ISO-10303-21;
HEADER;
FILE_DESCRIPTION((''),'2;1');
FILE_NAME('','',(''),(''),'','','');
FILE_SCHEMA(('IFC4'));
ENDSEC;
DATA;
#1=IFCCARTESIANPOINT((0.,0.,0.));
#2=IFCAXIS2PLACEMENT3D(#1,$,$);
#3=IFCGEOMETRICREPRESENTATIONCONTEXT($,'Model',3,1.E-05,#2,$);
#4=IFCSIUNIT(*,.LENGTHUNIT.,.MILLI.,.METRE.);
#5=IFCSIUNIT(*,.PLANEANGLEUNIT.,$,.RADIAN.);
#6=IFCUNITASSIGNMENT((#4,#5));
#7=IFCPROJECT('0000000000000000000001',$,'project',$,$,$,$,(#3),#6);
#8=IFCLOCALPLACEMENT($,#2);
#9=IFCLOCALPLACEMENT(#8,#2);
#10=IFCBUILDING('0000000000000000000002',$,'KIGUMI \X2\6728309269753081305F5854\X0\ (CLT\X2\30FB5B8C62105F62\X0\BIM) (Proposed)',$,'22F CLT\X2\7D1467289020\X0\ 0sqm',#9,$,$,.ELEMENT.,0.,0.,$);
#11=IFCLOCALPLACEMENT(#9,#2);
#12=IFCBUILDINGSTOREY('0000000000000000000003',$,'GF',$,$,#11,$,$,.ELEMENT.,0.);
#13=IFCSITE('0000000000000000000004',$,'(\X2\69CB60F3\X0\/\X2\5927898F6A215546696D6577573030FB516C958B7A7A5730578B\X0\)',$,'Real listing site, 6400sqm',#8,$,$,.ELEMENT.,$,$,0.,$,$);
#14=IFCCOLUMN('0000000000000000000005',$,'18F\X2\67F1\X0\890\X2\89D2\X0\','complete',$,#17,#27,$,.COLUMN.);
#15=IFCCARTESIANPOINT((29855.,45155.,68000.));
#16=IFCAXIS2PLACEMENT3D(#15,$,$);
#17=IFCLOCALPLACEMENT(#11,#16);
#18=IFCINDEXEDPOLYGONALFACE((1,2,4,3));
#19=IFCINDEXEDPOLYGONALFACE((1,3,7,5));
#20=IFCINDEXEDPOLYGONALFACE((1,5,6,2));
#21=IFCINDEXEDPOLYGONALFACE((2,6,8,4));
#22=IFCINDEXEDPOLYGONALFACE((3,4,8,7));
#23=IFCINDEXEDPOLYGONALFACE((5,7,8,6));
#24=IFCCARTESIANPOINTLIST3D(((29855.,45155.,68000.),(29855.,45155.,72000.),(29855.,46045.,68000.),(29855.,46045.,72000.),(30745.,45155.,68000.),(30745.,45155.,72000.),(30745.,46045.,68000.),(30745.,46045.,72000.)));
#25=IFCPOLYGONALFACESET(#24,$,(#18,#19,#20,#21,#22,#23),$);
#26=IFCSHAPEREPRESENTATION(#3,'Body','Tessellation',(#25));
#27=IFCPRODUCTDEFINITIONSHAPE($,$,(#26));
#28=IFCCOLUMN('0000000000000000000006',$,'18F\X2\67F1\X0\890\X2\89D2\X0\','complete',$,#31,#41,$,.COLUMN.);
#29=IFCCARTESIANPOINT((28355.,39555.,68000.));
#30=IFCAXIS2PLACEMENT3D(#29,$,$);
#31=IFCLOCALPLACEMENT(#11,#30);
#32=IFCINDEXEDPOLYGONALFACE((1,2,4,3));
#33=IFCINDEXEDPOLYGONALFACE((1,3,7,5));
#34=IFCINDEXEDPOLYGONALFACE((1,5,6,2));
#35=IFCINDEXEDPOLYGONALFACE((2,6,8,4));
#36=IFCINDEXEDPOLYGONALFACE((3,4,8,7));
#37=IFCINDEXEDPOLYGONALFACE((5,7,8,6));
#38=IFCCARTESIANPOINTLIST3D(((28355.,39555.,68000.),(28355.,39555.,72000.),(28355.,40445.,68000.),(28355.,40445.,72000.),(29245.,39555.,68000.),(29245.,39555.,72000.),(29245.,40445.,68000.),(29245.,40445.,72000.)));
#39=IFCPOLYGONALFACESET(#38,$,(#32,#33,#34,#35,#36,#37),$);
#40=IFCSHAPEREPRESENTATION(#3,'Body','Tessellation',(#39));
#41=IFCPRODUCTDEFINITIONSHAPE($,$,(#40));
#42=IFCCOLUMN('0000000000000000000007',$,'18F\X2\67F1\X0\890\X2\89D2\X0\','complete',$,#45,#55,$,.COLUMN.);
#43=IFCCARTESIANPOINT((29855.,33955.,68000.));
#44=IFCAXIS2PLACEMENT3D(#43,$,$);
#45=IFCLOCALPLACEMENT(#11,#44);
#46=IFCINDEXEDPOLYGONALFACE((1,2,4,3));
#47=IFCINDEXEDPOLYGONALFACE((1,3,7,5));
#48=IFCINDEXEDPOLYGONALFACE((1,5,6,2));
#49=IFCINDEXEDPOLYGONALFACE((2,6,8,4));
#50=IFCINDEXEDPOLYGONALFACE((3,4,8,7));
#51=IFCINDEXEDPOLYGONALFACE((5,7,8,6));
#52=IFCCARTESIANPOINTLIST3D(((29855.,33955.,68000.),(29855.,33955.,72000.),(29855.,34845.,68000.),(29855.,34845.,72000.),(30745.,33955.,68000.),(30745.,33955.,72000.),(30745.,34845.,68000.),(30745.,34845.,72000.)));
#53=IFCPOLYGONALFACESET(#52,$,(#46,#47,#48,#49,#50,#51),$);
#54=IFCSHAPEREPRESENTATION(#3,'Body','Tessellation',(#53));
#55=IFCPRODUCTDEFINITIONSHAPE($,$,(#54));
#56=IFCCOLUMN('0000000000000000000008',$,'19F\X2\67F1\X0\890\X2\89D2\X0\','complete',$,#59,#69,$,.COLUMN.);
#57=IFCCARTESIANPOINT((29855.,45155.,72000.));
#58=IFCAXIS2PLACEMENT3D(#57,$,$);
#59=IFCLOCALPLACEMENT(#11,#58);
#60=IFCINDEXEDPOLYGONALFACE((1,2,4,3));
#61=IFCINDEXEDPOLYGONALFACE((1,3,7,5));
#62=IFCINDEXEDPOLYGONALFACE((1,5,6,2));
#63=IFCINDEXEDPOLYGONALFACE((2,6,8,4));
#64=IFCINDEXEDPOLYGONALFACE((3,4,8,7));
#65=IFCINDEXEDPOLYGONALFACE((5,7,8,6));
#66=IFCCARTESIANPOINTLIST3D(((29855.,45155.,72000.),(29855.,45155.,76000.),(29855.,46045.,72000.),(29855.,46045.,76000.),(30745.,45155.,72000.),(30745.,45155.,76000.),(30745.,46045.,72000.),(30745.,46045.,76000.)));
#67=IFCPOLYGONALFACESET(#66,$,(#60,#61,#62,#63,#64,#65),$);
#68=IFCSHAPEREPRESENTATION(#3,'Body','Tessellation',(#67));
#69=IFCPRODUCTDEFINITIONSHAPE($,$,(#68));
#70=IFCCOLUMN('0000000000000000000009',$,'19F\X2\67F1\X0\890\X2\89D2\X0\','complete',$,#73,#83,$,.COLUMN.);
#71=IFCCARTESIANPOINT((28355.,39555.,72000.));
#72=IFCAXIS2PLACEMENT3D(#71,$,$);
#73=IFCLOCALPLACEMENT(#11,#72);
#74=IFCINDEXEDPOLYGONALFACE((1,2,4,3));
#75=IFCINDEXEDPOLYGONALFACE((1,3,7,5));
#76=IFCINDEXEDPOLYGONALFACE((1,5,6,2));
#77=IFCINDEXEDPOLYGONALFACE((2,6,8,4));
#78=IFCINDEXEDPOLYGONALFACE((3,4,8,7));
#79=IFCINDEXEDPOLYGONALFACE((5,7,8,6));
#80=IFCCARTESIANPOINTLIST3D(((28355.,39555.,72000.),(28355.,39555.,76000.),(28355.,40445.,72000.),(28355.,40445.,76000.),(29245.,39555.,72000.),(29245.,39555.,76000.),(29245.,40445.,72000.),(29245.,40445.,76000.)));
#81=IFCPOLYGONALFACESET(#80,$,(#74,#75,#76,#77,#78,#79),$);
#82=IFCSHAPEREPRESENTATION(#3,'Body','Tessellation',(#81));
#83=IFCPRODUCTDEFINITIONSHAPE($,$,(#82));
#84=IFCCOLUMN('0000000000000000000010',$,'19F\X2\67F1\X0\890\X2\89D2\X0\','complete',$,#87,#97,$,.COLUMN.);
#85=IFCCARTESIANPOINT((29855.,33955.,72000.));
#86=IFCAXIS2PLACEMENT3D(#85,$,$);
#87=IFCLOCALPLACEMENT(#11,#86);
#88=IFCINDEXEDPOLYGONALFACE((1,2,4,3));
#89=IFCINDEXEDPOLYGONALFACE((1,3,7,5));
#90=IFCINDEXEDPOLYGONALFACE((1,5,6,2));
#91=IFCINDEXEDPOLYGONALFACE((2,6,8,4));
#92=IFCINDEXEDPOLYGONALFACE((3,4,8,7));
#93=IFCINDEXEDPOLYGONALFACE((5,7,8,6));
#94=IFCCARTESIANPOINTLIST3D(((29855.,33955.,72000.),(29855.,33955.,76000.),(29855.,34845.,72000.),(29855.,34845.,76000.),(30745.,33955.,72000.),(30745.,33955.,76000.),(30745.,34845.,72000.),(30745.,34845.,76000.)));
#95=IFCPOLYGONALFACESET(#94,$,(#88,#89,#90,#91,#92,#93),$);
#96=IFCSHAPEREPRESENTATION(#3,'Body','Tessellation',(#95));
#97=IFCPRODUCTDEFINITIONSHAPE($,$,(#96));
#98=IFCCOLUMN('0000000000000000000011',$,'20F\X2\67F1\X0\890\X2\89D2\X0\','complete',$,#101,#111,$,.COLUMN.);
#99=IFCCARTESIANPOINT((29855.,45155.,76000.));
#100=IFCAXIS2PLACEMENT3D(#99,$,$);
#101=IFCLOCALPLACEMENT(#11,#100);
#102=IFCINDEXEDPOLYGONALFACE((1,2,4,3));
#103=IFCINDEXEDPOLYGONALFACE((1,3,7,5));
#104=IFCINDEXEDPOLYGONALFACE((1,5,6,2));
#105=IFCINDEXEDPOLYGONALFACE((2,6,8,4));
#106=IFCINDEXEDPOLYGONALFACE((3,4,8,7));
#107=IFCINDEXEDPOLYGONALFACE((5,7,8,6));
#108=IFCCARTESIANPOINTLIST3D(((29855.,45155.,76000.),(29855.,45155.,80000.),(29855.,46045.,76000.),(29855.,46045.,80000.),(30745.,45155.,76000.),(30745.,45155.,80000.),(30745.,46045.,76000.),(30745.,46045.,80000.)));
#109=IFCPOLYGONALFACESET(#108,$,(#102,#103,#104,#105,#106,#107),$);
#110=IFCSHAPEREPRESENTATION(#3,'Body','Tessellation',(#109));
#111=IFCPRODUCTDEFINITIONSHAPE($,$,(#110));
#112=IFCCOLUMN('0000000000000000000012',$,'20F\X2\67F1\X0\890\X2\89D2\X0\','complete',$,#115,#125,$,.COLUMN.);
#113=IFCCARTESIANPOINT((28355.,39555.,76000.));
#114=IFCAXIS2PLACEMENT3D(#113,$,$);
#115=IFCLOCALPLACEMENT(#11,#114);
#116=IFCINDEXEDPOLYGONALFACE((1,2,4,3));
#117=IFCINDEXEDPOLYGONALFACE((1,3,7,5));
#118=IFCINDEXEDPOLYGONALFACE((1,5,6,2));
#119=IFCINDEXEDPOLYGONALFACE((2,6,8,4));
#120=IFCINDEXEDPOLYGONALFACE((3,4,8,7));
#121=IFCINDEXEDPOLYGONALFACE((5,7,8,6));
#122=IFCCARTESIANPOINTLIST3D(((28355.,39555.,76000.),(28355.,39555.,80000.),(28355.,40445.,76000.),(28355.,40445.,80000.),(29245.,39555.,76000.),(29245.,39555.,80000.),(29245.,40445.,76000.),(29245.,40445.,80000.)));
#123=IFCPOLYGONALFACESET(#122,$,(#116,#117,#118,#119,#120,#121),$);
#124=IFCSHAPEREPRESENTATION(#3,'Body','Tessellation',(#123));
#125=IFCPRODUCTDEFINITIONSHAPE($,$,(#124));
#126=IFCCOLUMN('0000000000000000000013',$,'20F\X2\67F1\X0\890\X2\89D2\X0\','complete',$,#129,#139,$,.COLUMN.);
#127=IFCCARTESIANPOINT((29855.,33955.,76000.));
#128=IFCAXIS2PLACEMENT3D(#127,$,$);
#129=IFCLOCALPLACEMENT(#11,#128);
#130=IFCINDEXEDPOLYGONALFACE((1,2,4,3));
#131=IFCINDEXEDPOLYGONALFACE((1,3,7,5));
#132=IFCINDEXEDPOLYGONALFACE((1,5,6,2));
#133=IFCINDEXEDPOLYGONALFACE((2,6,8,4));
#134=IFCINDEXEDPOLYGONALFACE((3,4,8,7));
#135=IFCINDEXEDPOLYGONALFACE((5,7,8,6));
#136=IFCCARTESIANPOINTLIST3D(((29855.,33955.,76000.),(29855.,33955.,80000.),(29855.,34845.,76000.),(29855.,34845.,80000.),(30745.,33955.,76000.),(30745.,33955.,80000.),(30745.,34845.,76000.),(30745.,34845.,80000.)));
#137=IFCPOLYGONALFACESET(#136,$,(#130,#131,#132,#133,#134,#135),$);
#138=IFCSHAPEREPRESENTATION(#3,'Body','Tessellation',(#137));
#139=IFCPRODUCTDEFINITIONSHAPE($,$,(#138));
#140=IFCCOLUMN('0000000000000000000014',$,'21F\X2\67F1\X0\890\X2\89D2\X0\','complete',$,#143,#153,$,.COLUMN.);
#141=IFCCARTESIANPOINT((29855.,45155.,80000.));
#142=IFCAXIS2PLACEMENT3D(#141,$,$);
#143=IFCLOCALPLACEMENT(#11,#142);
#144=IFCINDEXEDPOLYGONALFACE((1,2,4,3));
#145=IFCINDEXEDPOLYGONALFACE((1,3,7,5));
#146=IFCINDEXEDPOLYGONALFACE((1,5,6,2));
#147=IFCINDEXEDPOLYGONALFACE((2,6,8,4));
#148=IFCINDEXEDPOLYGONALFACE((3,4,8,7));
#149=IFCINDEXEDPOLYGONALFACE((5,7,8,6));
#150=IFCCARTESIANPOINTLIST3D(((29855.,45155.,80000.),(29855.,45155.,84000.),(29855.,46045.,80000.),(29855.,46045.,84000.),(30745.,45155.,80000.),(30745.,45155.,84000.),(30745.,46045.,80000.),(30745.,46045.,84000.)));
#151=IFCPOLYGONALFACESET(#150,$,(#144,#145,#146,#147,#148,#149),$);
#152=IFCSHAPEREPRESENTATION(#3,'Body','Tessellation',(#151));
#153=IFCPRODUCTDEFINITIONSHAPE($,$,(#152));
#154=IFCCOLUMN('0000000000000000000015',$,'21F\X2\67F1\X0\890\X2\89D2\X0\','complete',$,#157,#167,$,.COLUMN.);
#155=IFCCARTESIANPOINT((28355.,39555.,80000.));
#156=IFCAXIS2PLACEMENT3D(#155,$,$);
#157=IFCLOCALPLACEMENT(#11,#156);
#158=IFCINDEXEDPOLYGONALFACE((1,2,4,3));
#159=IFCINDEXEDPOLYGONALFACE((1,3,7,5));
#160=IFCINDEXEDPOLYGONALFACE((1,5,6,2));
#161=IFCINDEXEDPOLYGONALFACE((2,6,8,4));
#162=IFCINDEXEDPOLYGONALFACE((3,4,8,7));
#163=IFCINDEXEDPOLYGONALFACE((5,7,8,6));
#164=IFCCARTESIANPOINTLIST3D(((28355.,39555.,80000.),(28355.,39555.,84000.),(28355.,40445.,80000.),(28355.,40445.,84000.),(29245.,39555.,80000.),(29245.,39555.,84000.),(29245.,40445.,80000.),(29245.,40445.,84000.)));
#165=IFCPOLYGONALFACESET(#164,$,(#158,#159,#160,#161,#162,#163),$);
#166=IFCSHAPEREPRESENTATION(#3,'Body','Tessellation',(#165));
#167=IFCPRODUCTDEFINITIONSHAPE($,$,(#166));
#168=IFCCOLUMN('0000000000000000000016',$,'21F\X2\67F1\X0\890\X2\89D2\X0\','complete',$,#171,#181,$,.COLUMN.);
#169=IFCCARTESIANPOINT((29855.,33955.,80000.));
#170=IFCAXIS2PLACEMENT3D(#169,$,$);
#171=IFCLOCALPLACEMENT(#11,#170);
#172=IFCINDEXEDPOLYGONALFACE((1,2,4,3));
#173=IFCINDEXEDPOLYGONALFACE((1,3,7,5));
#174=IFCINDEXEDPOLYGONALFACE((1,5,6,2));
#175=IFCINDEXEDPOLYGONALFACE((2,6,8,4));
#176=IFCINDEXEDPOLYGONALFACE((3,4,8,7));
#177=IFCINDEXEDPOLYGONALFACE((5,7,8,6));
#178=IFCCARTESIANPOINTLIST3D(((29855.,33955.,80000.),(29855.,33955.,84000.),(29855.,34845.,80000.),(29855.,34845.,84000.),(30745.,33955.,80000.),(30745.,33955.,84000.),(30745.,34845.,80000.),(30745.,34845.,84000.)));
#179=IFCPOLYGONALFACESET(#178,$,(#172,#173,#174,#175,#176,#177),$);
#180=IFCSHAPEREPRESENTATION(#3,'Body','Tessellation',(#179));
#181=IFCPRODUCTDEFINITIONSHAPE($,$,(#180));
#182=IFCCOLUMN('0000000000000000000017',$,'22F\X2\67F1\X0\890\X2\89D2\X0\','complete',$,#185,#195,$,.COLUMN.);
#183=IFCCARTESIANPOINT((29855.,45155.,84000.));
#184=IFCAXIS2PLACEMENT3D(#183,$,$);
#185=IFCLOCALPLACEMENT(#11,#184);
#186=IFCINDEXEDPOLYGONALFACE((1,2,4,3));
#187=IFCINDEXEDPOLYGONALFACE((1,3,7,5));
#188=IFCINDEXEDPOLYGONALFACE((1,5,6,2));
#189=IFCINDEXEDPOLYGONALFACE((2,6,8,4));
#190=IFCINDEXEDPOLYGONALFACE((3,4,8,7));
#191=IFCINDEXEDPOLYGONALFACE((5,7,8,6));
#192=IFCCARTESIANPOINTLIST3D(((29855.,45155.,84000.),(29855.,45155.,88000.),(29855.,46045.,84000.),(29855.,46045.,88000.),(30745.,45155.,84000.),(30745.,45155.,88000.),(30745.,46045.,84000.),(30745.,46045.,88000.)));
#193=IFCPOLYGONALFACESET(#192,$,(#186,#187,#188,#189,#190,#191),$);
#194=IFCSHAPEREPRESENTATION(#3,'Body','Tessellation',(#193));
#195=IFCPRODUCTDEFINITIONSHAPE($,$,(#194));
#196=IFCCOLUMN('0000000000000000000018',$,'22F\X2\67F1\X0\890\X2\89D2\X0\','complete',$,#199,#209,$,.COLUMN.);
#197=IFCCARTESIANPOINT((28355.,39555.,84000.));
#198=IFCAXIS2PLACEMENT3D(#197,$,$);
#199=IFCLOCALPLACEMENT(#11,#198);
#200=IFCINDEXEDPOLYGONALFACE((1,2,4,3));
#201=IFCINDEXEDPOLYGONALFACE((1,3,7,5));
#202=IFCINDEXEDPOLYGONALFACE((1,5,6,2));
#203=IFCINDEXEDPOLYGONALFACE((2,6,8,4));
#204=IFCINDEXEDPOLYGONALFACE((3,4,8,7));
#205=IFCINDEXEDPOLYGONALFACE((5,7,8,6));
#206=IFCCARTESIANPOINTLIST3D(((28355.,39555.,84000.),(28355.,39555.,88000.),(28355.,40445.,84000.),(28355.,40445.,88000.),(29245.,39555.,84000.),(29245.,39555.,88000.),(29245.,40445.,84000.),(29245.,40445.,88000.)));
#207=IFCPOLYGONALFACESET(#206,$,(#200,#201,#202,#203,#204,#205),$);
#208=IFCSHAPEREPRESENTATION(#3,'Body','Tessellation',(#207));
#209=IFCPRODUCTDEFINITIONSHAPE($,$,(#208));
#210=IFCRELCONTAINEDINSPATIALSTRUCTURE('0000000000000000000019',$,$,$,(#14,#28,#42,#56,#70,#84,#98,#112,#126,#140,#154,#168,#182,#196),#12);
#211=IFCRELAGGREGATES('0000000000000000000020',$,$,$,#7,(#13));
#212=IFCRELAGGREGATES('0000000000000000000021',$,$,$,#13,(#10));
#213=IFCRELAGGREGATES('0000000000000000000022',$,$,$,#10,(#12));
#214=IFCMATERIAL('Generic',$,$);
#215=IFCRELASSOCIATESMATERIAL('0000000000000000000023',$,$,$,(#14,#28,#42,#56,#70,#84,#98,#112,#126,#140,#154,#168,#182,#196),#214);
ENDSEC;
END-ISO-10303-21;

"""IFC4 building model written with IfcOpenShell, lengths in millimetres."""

from ifc_helpers import new_model, si_unit, frame, frame_2d, origin, place, context, project, spatial, rectangle, extrude, material, element, save


model = new_model("IFC4")

# Units and contexts
model_context = context("Model", 3, precision=1e-05, world=origin())
ifc_project = project(units=[si_unit("LENGTHUNIT", "METRE", prefix="MILLI"), si_unit("PLANEANGLEUNIT", "RADIAN")], contexts=[model_context])

# Site, building, storey
site_placement = place(None, origin())
site = spatial("IfcSite", under=ifc_project, at=site_placement, Name="(構想/大規模商業敷地・公開空地型)", ObjectType="Real listing site, 6400sqm", CompositionType="ELEMENT", RefElevation=0.0)
building_placement = place(site_placement, origin())
building = spatial("IfcBuilding", under=site, at=building_placement, Name="KIGUMI 木を極めた塔 (CLT・完成形BIM) (Proposed)", ObjectType="22F CLT純木造 0sqm", CompositionType="ELEMENT", ElevationOfRefHeight=0.0, ElevationOfTerrain=0.0)
storey_placement = place(building_placement, origin())
storey = spatial("IfcBuildingStorey", under=building, at=storey_placement, Name="GF", CompositionType="ELEMENT", Elevation=0.0)

# Columns
ifc_material = material(Name="Generic")
column_1_placement = place(storey_placement, frame((29855.0, 45155.0, 68000.0)))
element("IfcColumn", 1, at=column_1_placement, inside=storey, material=ifc_material, Name="18F柱890角", Description="complete", PredefinedType="COLUMN", context=model_context, shape_type="SweptSolid", body=[
    extrude(rectangle(XDim=890.0, YDim=890.0, at=frame_2d((445.0, 445.0))), frame((29855.0, 45155.0, 68000.0)), (0.0, 0.0, 1.0), 4000.0),
])
column_2_placement = place(storey_placement, frame((28355.0, 39555.0, 68000.0)))
element("IfcColumn", 2, at=column_2_placement, inside=storey, material=ifc_material, Name="18F柱890角", Description="complete", PredefinedType="COLUMN", context=model_context, shape_type="SweptSolid", body=[
    extrude(rectangle(XDim=890.0, YDim=890.0, at=frame_2d((445.0, 445.0))), frame((28355.0, 39555.0, 68000.0)), (0.0, 0.0, 1.0), 4000.0),
])
column_3_placement = place(storey_placement, frame((29855.0, 33955.0, 68000.0)))
element("IfcColumn", 3, at=column_3_placement, inside=storey, material=ifc_material, Name="18F柱890角", Description="complete", PredefinedType="COLUMN", context=model_context, shape_type="SweptSolid", body=[
    extrude(rectangle(XDim=890.0, YDim=890.0, at=frame_2d((445.0, 445.0))), frame((29855.0, 33955.0, 68000.0)), (0.0, 0.0, 1.0), 4000.0),
])
column_4_placement = place(storey_placement, frame((29855.0, 45155.0, 72000.0)))
element("IfcColumn", 4, at=column_4_placement, inside=storey, material=ifc_material, Name="19F柱890角", Description="complete", PredefinedType="COLUMN", context=model_context, shape_type="SweptSolid", body=[
    extrude(rectangle(XDim=890.0, YDim=890.0, at=frame_2d((445.0, 445.0))), frame((29855.0, 45155.0, 72000.0)), (0.0, 0.0, 1.0), 4000.0),
])
column_5_placement = place(storey_placement, frame((28355.0, 39555.0, 72000.0)))
element("IfcColumn", 5, at=column_5_placement, inside=storey, material=ifc_material, Name="19F柱890角", Description="complete", PredefinedType="COLUMN", context=model_context, shape_type="SweptSolid", body=[
    extrude(rectangle(XDim=890.0, YDim=890.0, at=frame_2d((445.0, 445.0))), frame((28355.0, 39555.0, 72000.0)), (0.0, 0.0, 1.0), 4000.0),
])
column_6_placement = place(storey_placement, frame((29855.0, 33955.0, 72000.0)))
element("IfcColumn", 6, at=column_6_placement, inside=storey, material=ifc_material, Name="19F柱890角", Description="complete", PredefinedType="COLUMN", context=model_context, shape_type="SweptSolid", body=[
    extrude(rectangle(XDim=890.0, YDim=890.0, at=frame_2d((445.0, 445.0))), frame((29855.0, 33955.0, 72000.0)), (0.0, 0.0, 1.0), 4000.0),
])
column_7_placement = place(storey_placement, frame((29855.0, 45155.0, 76000.0)))
element("IfcColumn", 7, at=column_7_placement, inside=storey, material=ifc_material, Name="20F柱890角", Description="complete", PredefinedType="COLUMN", context=model_context, shape_type="SweptSolid", body=[
    extrude(rectangle(XDim=890.0, YDim=890.0, at=frame_2d((445.0, 445.0))), frame((29855.0, 45155.0, 76000.0)), (0.0, 0.0, 1.0), 4000.0),
])
column_8_placement = place(storey_placement, frame((28355.0, 39555.0, 76000.0)))
element("IfcColumn", 8, at=column_8_placement, inside=storey, material=ifc_material, Name="20F柱890角", Description="complete", PredefinedType="COLUMN", context=model_context, shape_type="SweptSolid", body=[
    extrude(rectangle(XDim=890.0, YDim=890.0, at=frame_2d((445.0, 445.0))), frame((28355.0, 39555.0, 76000.0)), (0.0, 0.0, 1.0), 4000.0),
])
column_9_placement = place(storey_placement, frame((29855.0, 33955.0, 76000.0)))
element("IfcColumn", 9, at=column_9_placement, inside=storey, material=ifc_material, Name="20F柱890角", Description="complete", PredefinedType="COLUMN", context=model_context, shape_type="SweptSolid", body=[
    extrude(rectangle(XDim=890.0, YDim=890.0, at=frame_2d((445.0, 445.0))), frame((29855.0, 33955.0, 76000.0)), (0.0, 0.0, 1.0), 4000.0),
])
column_10_placement = place(storey_placement, frame((29855.0, 45155.0, 80000.0)))
element("IfcColumn", 10, at=column_10_placement, inside=storey, material=ifc_material, Name="21F柱890角", Description="complete", PredefinedType="COLUMN", context=model_context, shape_type="SweptSolid", body=[
    extrude(rectangle(XDim=890.0, YDim=890.0, at=frame_2d((445.0, 445.0))), frame((29855.0, 45155.0, 80000.0)), (0.0, 0.0, 1.0), 4000.0),
])
column_11_placement = place(storey_placement, frame((28355.0, 39555.0, 80000.0)))
element("IfcColumn", 11, at=column_11_placement, inside=storey, material=ifc_material, Name="21F柱890角", Description="complete", PredefinedType="COLUMN", context=model_context, shape_type="SweptSolid", body=[
    extrude(rectangle(XDim=890.0, YDim=890.0, at=frame_2d((445.0, 445.0))), frame((28355.0, 39555.0, 80000.0)), (0.0, 0.0, 1.0), 4000.0),
])
column_12_placement = place(storey_placement, frame((29855.0, 33955.0, 80000.0)))
element("IfcColumn", 12, at=column_12_placement, inside=storey, material=ifc_material, Name="21F柱890角", Description="complete", PredefinedType="COLUMN", context=model_context, shape_type="SweptSolid", body=[
    extrude(rectangle(XDim=890.0, YDim=890.0, at=frame_2d((445.0, 445.0))), frame((29855.0, 33955.0, 80000.0)), (0.0, 0.0, 1.0), 4000.0),
])
column_13_placement = place(storey_placement, frame((29855.0, 45155.0, 84000.0)))
element("IfcColumn", 13, at=column_13_placement, inside=storey, material=ifc_material, Name="22F柱890角", Description="complete", PredefinedType="COLUMN", context=model_context, shape_type="SweptSolid", body=[
    extrude(rectangle(XDim=890.0, YDim=890.0, at=frame_2d((445.0, 445.0))), frame((29855.0, 45155.0, 84000.0)), (0.0, 0.0, 1.0), 4000.0),
])
column_14_placement = place(storey_placement, frame((28355.0, 39555.0, 84000.0)))
element("IfcColumn", 14, at=column_14_placement, inside=storey, material=ifc_material, Name="22F柱890角", Description="complete", PredefinedType="COLUMN", context=model_context, shape_type="SweptSolid", body=[
    extrude(rectangle(XDim=890.0, YDim=890.0, at=frame_2d((445.0, 445.0))), frame((28355.0, 39555.0, 84000.0)), (0.0, 0.0, 1.0), 4000.0),
])

save(model, "model.ifc")
